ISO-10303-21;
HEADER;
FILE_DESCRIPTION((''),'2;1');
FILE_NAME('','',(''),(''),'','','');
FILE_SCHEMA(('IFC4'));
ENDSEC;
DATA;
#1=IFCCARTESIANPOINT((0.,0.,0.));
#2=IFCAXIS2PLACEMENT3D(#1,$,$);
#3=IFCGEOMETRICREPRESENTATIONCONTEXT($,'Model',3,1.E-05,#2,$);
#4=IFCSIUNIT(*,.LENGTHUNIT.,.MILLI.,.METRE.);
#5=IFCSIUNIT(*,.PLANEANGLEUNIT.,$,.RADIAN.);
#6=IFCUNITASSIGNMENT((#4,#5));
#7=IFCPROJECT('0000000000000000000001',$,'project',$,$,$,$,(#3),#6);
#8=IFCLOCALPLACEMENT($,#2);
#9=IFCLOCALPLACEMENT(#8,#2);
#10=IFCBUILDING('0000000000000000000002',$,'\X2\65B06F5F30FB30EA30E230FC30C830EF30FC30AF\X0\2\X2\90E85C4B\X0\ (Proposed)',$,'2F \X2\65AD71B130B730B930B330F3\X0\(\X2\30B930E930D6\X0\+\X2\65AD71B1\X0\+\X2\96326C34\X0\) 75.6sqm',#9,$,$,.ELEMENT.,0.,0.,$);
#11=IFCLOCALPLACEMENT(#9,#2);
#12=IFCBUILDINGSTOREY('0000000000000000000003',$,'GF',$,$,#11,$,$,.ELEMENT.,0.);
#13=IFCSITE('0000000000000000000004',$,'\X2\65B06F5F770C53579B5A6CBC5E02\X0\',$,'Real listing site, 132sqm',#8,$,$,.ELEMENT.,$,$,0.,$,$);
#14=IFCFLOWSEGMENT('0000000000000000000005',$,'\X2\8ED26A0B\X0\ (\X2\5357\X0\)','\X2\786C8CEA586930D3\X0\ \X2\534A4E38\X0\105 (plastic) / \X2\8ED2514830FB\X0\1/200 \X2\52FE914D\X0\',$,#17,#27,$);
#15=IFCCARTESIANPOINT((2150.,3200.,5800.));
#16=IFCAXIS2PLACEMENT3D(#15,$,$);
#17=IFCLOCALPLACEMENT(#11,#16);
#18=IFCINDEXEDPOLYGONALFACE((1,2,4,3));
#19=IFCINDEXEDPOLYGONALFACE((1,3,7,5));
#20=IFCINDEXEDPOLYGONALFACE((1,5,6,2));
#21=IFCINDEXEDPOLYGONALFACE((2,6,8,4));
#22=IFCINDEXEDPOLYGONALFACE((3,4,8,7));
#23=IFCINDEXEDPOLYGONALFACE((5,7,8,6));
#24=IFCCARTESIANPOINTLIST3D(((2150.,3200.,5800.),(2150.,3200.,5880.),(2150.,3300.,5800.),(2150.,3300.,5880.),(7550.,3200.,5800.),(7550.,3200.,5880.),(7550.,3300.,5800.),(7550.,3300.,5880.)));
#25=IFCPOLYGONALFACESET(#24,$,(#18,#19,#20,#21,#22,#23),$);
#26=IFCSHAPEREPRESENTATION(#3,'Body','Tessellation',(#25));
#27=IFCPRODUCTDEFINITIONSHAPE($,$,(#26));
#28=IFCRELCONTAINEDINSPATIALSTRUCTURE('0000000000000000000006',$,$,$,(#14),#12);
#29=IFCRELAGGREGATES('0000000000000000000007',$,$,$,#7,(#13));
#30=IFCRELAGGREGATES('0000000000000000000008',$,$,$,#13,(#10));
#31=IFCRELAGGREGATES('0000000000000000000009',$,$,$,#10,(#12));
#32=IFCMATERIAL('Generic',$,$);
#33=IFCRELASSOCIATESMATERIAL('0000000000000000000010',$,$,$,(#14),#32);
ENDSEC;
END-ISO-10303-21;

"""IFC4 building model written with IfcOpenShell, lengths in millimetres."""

from ifc_helpers import new_model, si_unit, frame, frame_2d, origin, place, context, project, spatial, rectangle, extrude, material, element, save


model = new_model("IFC4")

# Units and contexts
model_context = context("Model", 3, precision=1e-05, world=origin())
ifc_project = project(units=[si_unit("LENGTHUNIT", "METRE", prefix="MILLI"), si_unit("PLANEANGLEUNIT", "RADIAN")], contexts=[model_context])

# Site, building, storey
site_placement = place(None, origin())
site = spatial("IfcSite", under=ifc_project, at=site_placement, Name="新潟県南魚沼市", ObjectType="Real listing site, 132sqm", CompositionType="ELEMENT", RefElevation=0.0)
building_placement = place(site_placement, origin())
building = spatial("IfcBuilding", under=site, at=building_placement, Name="新潟・リモートワーク2部屋 (Proposed)", ObjectType="2F 断熱シスコン(スラブ+断熱+防水) 75.6sqm", CompositionType="ELEMENT", ElevationOfRefHeight=0.0, ElevationOfTerrain=0.0)
storey_placement = place(building_placement, origin())
storey = spatial("IfcBuildingStorey", under=building, at=storey_placement, Name="GF", CompositionType="ELEMENT", Elevation=0.0)

# Flow segment
ifc_material_1 = material(Name="Generic")
flow_segment_placement = place(storey_placement, frame((2150.0, 3200.0, 5800.0)))
element("IfcFlowSegment", 1, at=flow_segment_placement, inside=storey, material=ifc_material_1, Name="軒樋 (南)", Description="硬質塩ビ 半丸105 (plastic) / 軒先・1/200 勾配", context=model_context, shape_type="SweptSolid", body=[
    extrude(rectangle(XDim=5400.0, YDim=100.0, at=frame_2d((2700.0, 50.0))), frame((2150.0, 3200.0, 5800.0)), (0.0, 0.0, 1.0), 80.0),
])

save(model, "model.ifc")
